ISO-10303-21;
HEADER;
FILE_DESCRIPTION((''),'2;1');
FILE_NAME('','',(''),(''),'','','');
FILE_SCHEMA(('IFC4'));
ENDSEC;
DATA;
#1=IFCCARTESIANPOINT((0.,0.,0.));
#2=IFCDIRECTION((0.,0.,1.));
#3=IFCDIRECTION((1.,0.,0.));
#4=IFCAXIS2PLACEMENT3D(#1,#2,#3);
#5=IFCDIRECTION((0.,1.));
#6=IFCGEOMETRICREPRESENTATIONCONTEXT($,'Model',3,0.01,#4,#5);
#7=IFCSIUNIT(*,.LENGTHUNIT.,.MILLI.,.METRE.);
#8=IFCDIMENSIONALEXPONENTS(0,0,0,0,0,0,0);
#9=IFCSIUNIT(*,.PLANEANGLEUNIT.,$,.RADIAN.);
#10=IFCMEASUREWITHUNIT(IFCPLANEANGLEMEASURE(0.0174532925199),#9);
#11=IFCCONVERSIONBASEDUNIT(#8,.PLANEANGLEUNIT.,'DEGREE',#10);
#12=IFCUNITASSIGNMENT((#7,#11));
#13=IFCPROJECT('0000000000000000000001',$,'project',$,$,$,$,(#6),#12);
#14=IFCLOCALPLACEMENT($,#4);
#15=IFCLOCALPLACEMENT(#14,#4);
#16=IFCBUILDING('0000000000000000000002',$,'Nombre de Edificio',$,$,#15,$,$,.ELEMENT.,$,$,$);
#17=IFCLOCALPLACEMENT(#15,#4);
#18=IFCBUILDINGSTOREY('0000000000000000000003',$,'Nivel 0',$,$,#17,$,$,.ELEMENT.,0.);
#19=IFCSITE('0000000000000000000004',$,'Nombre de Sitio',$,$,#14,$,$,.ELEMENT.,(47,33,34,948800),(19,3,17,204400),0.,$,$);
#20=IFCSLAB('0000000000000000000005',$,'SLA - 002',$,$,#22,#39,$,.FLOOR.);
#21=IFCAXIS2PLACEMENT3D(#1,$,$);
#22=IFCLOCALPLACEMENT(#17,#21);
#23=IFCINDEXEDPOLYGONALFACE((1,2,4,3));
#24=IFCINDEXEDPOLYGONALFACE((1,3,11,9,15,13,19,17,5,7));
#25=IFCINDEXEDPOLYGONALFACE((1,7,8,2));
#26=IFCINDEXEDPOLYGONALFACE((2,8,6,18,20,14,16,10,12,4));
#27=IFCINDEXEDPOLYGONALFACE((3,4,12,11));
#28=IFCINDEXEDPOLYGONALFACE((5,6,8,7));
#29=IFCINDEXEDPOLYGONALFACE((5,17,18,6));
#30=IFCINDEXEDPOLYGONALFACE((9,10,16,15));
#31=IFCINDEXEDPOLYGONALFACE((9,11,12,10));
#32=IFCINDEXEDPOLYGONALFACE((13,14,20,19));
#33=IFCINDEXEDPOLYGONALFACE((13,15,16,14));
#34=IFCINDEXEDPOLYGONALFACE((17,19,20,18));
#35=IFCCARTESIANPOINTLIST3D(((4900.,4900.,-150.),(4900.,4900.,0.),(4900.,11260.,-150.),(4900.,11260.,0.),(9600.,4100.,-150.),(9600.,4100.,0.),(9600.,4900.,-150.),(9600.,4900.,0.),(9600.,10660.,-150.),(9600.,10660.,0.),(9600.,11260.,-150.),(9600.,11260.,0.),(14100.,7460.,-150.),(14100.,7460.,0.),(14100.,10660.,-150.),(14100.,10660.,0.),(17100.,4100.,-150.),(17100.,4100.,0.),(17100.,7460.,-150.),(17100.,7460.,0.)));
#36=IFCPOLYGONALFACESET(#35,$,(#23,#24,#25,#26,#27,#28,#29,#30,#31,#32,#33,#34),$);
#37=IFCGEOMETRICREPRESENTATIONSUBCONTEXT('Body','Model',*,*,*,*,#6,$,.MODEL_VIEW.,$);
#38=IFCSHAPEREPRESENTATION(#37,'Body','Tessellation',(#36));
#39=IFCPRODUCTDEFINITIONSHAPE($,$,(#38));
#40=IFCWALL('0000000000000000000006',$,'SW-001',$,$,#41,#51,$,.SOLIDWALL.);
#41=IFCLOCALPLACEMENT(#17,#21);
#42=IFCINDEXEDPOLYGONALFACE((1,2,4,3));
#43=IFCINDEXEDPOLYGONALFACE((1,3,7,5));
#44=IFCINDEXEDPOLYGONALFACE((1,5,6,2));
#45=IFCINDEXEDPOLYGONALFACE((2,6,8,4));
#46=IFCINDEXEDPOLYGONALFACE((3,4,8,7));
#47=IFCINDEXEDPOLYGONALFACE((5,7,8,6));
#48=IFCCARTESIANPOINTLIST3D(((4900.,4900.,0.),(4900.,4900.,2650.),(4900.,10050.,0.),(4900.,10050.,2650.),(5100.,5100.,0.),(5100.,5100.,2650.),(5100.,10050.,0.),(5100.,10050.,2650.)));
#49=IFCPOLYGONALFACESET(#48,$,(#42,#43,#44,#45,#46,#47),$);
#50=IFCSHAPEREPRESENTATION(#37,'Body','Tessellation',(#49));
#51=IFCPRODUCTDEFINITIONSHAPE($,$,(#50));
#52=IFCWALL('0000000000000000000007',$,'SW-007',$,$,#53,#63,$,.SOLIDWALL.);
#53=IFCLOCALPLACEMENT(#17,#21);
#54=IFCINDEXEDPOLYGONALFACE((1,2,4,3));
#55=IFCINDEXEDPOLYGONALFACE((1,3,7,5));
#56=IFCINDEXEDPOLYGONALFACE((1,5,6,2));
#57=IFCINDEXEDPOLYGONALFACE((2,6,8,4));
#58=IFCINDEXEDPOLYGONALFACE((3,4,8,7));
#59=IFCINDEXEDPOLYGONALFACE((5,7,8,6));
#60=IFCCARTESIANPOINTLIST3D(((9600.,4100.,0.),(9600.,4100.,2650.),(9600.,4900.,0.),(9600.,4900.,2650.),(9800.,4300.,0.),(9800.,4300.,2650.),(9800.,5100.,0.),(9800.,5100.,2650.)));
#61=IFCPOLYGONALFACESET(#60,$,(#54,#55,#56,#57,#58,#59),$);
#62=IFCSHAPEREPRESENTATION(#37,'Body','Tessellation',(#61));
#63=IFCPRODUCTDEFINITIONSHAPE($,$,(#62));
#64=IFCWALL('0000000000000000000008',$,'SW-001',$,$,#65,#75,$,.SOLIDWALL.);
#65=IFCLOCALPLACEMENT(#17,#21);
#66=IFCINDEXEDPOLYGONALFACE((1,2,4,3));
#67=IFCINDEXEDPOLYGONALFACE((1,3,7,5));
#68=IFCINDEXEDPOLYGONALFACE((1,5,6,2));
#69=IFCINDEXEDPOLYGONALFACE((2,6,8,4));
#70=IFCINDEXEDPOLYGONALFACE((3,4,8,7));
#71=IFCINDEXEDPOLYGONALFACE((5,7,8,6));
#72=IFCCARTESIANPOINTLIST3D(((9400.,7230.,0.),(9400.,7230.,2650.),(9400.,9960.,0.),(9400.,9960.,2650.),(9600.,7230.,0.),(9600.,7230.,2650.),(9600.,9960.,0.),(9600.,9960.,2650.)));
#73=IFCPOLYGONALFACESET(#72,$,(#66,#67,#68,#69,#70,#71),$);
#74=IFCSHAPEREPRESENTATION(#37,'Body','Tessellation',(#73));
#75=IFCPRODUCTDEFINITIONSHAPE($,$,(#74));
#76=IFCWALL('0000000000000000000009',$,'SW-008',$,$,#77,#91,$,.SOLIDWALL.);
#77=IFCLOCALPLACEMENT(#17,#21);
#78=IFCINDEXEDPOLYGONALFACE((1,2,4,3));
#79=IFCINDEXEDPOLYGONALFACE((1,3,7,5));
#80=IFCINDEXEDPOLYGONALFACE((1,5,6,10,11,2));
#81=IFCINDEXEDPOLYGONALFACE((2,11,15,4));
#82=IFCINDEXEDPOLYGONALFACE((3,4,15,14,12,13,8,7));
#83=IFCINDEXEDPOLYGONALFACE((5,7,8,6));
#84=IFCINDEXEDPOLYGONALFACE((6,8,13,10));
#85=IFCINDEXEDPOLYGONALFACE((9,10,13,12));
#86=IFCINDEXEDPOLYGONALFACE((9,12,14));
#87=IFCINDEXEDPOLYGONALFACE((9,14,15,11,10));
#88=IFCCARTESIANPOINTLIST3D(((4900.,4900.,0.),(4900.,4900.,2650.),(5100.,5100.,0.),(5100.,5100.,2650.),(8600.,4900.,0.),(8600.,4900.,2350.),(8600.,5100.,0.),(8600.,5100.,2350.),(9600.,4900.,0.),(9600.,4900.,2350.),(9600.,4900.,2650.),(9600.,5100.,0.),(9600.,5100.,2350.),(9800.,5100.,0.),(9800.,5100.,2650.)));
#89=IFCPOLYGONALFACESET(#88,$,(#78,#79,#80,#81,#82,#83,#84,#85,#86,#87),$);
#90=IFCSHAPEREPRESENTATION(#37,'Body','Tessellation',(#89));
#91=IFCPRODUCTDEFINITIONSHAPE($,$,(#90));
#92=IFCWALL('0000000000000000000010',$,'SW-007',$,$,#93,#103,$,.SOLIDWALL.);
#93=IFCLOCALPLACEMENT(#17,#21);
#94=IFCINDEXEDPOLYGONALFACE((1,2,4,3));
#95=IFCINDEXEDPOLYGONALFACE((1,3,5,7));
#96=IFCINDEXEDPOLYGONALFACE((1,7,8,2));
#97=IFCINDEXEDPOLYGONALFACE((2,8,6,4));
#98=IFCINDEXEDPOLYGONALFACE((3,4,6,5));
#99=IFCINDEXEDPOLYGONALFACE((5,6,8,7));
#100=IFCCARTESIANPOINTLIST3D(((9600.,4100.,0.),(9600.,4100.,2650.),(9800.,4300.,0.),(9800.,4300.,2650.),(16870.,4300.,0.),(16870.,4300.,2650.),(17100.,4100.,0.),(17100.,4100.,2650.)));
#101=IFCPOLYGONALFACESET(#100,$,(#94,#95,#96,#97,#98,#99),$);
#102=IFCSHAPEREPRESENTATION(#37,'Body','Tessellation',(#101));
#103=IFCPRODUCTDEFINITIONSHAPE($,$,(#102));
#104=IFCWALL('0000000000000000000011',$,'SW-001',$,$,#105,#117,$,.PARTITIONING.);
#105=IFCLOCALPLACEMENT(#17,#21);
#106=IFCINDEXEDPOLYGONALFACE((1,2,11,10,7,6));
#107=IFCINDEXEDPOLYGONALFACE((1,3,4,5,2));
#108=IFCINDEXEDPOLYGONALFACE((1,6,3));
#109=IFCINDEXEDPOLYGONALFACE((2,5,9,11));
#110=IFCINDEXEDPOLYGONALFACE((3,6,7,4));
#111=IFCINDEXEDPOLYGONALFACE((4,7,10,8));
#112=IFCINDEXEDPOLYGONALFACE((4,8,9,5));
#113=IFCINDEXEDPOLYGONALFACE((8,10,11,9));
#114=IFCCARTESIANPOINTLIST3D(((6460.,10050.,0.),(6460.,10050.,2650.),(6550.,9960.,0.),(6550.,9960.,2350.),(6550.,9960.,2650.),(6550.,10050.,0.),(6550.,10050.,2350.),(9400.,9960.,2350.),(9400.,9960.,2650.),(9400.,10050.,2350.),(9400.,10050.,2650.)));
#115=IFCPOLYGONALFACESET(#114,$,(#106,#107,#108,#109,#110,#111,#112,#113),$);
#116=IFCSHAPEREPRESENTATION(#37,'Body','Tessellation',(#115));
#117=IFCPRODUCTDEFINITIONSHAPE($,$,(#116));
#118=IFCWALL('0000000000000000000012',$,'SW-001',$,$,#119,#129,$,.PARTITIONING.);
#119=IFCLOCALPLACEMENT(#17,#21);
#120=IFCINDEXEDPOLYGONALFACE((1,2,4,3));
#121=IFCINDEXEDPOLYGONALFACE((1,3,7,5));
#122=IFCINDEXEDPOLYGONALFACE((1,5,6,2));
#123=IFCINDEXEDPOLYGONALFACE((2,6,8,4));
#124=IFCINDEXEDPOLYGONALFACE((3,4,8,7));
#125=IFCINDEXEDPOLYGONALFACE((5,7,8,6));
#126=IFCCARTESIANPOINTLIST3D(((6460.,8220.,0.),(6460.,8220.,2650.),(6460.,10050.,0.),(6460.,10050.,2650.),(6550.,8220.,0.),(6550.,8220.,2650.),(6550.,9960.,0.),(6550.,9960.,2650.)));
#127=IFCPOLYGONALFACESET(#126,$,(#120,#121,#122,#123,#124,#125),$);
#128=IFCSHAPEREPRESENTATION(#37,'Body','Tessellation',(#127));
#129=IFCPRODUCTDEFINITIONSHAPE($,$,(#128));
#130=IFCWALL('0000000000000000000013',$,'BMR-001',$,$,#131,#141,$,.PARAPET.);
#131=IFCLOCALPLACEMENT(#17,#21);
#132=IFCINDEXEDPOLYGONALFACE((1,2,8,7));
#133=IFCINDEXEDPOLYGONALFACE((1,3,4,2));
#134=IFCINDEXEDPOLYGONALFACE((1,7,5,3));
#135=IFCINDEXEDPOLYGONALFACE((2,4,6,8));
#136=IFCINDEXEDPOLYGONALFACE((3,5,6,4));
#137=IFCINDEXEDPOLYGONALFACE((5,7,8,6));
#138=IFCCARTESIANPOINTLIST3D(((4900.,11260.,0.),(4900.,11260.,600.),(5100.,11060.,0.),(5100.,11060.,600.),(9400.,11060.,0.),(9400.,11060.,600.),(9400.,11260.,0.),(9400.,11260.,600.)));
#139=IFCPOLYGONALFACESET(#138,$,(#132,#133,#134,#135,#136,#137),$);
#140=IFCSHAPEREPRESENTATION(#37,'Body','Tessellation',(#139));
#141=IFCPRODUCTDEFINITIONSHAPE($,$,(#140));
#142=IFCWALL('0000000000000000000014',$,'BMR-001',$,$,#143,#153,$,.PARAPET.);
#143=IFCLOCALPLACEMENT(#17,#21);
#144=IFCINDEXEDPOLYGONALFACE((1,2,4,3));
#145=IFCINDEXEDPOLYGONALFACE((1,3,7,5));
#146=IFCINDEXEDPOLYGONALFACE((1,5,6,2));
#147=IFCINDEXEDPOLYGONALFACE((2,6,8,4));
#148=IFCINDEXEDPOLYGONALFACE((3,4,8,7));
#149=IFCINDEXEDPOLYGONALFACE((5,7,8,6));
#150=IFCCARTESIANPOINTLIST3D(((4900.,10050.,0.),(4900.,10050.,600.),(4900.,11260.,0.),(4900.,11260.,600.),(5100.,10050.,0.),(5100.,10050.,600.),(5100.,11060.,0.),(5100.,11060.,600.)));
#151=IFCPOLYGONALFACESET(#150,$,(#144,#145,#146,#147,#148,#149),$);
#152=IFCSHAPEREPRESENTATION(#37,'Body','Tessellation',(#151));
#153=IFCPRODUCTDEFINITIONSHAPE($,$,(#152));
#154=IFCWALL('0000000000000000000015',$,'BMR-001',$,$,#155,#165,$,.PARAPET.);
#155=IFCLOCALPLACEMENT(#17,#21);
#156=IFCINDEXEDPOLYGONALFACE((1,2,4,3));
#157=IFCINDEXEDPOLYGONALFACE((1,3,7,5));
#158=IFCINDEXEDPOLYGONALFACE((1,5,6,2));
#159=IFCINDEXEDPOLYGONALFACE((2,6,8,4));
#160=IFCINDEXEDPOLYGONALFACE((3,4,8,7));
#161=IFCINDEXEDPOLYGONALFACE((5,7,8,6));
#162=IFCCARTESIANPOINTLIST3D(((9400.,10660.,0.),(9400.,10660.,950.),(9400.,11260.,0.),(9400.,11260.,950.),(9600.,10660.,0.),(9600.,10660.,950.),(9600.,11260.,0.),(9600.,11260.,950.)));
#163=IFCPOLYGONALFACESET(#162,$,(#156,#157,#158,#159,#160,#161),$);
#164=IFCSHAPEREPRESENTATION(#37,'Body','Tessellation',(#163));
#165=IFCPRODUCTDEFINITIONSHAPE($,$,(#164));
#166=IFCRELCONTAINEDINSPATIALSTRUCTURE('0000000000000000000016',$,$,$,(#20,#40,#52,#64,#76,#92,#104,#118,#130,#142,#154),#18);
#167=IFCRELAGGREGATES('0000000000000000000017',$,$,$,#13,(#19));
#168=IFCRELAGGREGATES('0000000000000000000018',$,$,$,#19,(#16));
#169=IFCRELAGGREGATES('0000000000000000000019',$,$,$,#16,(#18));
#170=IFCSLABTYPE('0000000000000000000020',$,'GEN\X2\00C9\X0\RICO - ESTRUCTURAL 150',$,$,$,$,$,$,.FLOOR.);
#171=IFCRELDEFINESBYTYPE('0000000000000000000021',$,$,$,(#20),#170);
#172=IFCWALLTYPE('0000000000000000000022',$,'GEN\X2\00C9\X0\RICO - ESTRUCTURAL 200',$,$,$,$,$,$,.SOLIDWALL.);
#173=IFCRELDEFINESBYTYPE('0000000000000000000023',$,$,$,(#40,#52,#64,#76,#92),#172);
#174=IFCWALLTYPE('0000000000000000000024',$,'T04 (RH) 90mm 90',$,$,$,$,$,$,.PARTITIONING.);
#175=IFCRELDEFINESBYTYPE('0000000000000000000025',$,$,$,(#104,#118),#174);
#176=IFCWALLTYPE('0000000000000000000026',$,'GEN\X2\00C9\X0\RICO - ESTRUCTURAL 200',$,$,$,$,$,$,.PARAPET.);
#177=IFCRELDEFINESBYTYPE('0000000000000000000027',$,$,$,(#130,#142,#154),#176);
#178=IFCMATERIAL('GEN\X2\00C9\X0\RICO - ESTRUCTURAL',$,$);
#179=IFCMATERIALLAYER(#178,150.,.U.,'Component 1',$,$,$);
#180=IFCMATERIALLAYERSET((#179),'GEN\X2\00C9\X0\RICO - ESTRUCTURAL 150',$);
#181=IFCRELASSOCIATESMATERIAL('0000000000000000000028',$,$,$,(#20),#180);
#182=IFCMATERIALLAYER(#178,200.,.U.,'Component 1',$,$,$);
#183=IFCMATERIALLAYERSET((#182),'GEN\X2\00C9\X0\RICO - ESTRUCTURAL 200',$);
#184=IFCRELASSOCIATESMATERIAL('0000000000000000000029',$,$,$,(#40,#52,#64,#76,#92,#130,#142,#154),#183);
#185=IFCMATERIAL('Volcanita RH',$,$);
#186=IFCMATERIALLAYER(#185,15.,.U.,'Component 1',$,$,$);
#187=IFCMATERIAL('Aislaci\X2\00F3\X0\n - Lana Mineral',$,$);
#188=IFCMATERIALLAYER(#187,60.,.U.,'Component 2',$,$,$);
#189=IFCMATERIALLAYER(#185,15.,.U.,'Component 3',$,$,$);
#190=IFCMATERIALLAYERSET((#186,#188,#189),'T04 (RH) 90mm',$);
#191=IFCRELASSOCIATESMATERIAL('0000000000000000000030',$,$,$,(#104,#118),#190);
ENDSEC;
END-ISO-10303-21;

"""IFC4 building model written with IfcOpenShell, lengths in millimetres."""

from ifc_helpers import new_model, entity, si_unit, converted_unit, direction, frame, origin_with_axes, origin_2d_with_axis, place, context, subcontext, project, spatial, line, indexed_curve, rectangle, outline, extrude, material, layer, layer_set, layer_usage, type_object, element, save


model = new_model("IFC4")

# Units and contexts
model_context = context("Model", 3, precision=0.01, world=origin_with_axes(), true_north=direction((0.0, 1.0)))
body_context = subcontext(model_context, "Body", "Model", "MODEL_VIEW")
ifc_project = project(units=[si_unit("LENGTHUNIT", "METRE", prefix="MILLI"), converted_unit("PLANEANGLEUNIT", "DEGREE", entity("IfcPlaneAngleMeasure", 0.0174532925199), si_unit("PLANEANGLEUNIT", "RADIAN"), dimensions=[0, 0, 0, 0, 0, 0, 0])], contexts=[model_context])

# Site, building, storey
site_placement = place(None, origin_with_axes())
site = spatial("IfcSite", under=ifc_project, at=site_placement, Name="Nombre de Sitio", CompositionType="ELEMENT", RefLatitude=(47, 33, 34, 948800), RefLongitude=(19, 3, 17, 204400), RefElevation=0.0)
building_placement = place(site_placement, origin_with_axes())
building = spatial("IfcBuilding", under=site, at=building_placement, Name="Nombre de Edificio", CompositionType="ELEMENT")
storey_placement = place(building_placement, origin_with_axes())
storey = spatial("IfcBuildingStorey", under=building, at=storey_placement, Name="Nivel 0", CompositionType="ELEMENT", Elevation=0.0)

# Slab
ifc_material_1 = material(Name="GENÉRICO - ESTRUCTURAL")
ifc_layer_1 = layer(ifc_material_1, 150.0, ventilated="UNKNOWN", Name="Component 1")
ifc_layer_set_1 = layer_set([ifc_layer_1], Name="GENÉRICO - ESTRUCTURAL 150")
ifc_layer_usage_1 = layer_usage(ifc_layer_set_1, "AXIS3", "NEGATIVE", 150.0)
slab_type = type_object("IfcSlabType", Name="GENÉRICO - ESTRUCTURAL 150", PredefinedType="FLOOR")
slab_placement = place(storey_placement, frame((4900.0, 4900.0, 0.0), z_axis=(0.0, 0.0, 1.0), x_axis=(1.0, 0.0, 0.0)))
element("IfcSlab", 1, at=slab_placement, inside=storey, type_object=slab_type, material=ifc_layer_usage_1, Name="SLA - 002", PredefinedType="FLOOR", context=body_context, shape_type="SweptSolid", body=[
    extrude(outline(indexed_curve([(0.0, 0.0), (4700.0, 0.0), (4700.0, -800.0), (12200.0, -800.0), (12200.0, 2560.0), (9200.0, 2560.0), (9200.0, 5760.0), (4700.0, 5760.0), (4700.0, 6360.0), (0.0, 6360.0)], segments=[line(1, 2, 3, 4, 5, 6, 7, 8, 9, 10, 1)])), frame((0.0, 0.0, -150.0), z_axis=(0.0, 0.0, 1.0), x_axis=(1.0, 0.0, 0.0)), (0.0, 0.0, 1.0), 150.0),
])

# Walls
ifc_layer_2 = layer(ifc_material_1, 200.0, ventilated="UNKNOWN", Name="Component 1")
ifc_layer_set_2 = layer_set([ifc_layer_2], Name="GENÉRICO - ESTRUCTURAL 200")
ifc_layer_usage_2 = layer_usage(ifc_layer_set_2, "AXIS2", "POSITIVE", -100.0)
wall_type_1 = type_object("IfcWallType", Name="GENÉRICO - ESTRUCTURAL 200", PredefinedType="SOLIDWALL")
wall_1_placement = place(storey_placement, frame((5000.0, 5000.0, 0.0), z_axis=(0.0, 0.0, 1.0), x_axis=(0.0, 1.0, 0.0)))
element("IfcWall", 2, at=wall_1_placement, inside=storey, type_object=wall_type_1, material=ifc_layer_usage_2, Name="SW-001", PredefinedType="SOLIDWALL", context=body_context, shape_type="SweptSolid", body=[
    extrude(outline(indexed_curve([(100.0, -100.0), (5050.0, -100.0), (5050.0, 100.0), (-100.0, 100.0)], segments=[line(1, 2, 3, 4, 1)])), origin_with_axes(), (0.0, 0.0, 1.0), 2650.0),
])
ifc_layer_usage_3 = layer_usage(ifc_layer_set_2, "AXIS2", "POSITIVE", -100.0)
wall_2_placement = place(storey_placement, frame((9700.0, 4200.0, 0.0), z_axis=(0.0, 0.0, 1.0), x_axis=(0.0, 1.0, 0.0)))
element("IfcWall", 3, at=wall_2_placement, inside=storey, type_object=wall_type_1, material=ifc_layer_usage_3, Name="SW-007", PredefinedType="SOLIDWALL", context=body_context, shape_type="SweptSolid", body=[
    extrude(outline(indexed_curve([(100.0, -100.0), (900.0, -100.0), (700.0, 100.0), (-100.0, 100.0)], segments=[line(1, 2, 3, 4, 1)])), origin_with_axes(), (0.0, 0.0, 1.0), 2650.0),
])
ifc_layer_usage_4 = layer_usage(ifc_layer_set_2, "AXIS2", "POSITIVE", -100.0)
wall_3_placement = place(storey_placement, frame((9500.0, 7230.0, 0.0), z_axis=(0.0, 0.0, 1.0), x_axis=(0.0, 1.0, 0.0)))
element("IfcWall", 4, at=wall_3_placement, inside=storey, type_object=wall_type_1, material=ifc_layer_usage_4, Name="SW-001", PredefinedType="SOLIDWALL", context=body_context, shape_type="SweptSolid", body=[
    extrude(outline(indexed_curve([(0.0, -100.0), (2730.0, -100.0), (2730.0, 100.0), (0.0, 100.0)], segments=[line(1, 2, 3, 4, 1)])), origin_with_axes(), (0.0, 0.0, 1.0), 2650.0),
])

# Wall, opening
ifc_layer_usage_5 = layer_usage(ifc_layer_set_2, "AXIS2", "POSITIVE", -100.0)
wall_4_placement = place(storey_placement, frame((9700.0, 5000.0, 0.0), z_axis=(0.0, 0.0, 1.0), x_axis=(-1.0, 0.0, 0.0)))
wall_4 = element("IfcWall", 5, at=wall_4_placement, inside=storey, type_object=wall_type_1, material=ifc_layer_usage_5, Name="SW-008", PredefinedType="SOLIDWALL", context=body_context, shape_type="SweptSolid", body=[
    extrude(outline(indexed_curve([(-100.0, -100.0), (4600.0, -100.0), (4800.0, 100.0), (100.0, 100.0)], segments=[line(1, 2, 3, 4, 1)])), origin_with_axes(), (0.0, 0.0, 1.0), 2650.0),
])
opening_1_placement = place(wall_4_placement, frame((600.0, 0.0, 0.0), z_axis=(0.0, 0.0, 1.0), x_axis=(1.0, 0.0, 0.0)))
element("IfcOpeningElement", 6, at=opening_1_placement, cuts=wall_4, context=body_context, shape_type="SweptSolid", body=[
    extrude(rectangle(XDim=1000.0, YDim=2350.0, at=origin_2d_with_axis()), frame((0.0, 200.0, 1175.0), z_axis=(0.0, -1.0, 0.0), x_axis=(-1.0, 0.0, 0.0)), (0.0, 0.0, 1.0), 600.0),
])

# Wall
ifc_layer_usage_6 = layer_usage(ifc_layer_set_2, "AXIS2", "POSITIVE", -100.0)
wall_5_placement = place(storey_placement, frame((9700.0, 4200.0, 0.0), z_axis=(0.0, 0.0, 1.0), x_axis=(1.0, 0.0, 0.0)))
element("IfcWall", 7, at=wall_5_placement, inside=storey, type_object=wall_type_1, material=ifc_layer_usage_6, Name="SW-007", PredefinedType="SOLIDWALL", context=body_context, shape_type="SweptSolid", body=[
    extrude(outline(indexed_curve([(-100.0, -100.0), (7400.0, -100.0), (7170.0, 100.0), (100.0, 100.0)], segments=[line(1, 2, 3, 4, 1)])), origin_with_axes(), (0.0, 0.0, 1.0), 2650.0),
])

# Wall, opening
ifc_material_2 = material(Name="Volcanita RH")
ifc_layer_3 = layer(ifc_material_2, 15.0, ventilated="UNKNOWN", Name="Component 1")
ifc_material_3 = material(Name="Aislación - Lana Mineral")
ifc_layer_4 = layer(ifc_material_3, 60.0, ventilated="UNKNOWN", Name="Component 2")
ifc_layer_5 = layer(ifc_material_2, 15.0, ventilated="UNKNOWN", Name="Component 3")
ifc_layer_set_3 = layer_set([ifc_layer_3, ifc_layer_4, ifc_layer_5], Name="T04 (RH) 90mm")
wall_type_2 = type_object("IfcWallType", Name="T04 (RH) 90mm 90", PredefinedType="PARTITIONING")
ifc_layer_usage_7 = layer_usage(ifc_layer_set_3, "AXIS2", "POSITIVE", -45.0)
wall_6_placement = place(storey_placement, frame((6505.0, 10005.0, 0.0), z_axis=(0.0, 0.0, 1.0), x_axis=(1.0, 0.0, 0.0)))
wall_6 = element("IfcWall", 8, at=wall_6_placement, inside=storey, type_object=wall_type_2, material=ifc_layer_usage_7, Name="SW-001", PredefinedType="PARTITIONING", context=body_context, shape_type="SweptSolid", body=[
    extrude(outline(indexed_curve([(45.0, -45.0), (2895.0, -45.0), (2895.0, 45.0), (-45.0, 45.0)], segments=[line(1, 2, 3, 4, 1)])), origin_with_axes(), (0.0, 0.0, 1.0), 2650.0),
])
opening_2_placement = place(wall_6_placement, frame((1470.0, 0.0, 0.0), z_axis=(0.0, 0.0, 1.0), x_axis=(1.0, 0.0, 0.0)))
element("IfcOpeningElement", 9, at=opening_2_placement, cuts=wall_6, context=body_context, shape_type="SweptSolid", body=[
    extrude(rectangle(XDim=2850.0, YDim=2350.0, at=origin_2d_with_axis()), frame((0.0, 90.0, 1175.0), z_axis=(0.0, -1.0, 0.0), x_axis=(1.0, 0.0, 0.0)), (0.0, 0.0, 1.0), 270.0),
])

# Walls
ifc_layer_usage_8 = layer_usage(ifc_layer_set_3, "AXIS2", "POSITIVE", -45.0)
wall_7_placement = place(storey_placement, frame((6505.0, 10005.0, 0.0), z_axis=(0.0, 0.0, 1.0), x_axis=(0.0, -1.0, 0.0)))
element("IfcWall", 10, at=wall_7_placement, inside=storey, type_object=wall_type_2, material=ifc_layer_usage_8, Name="SW-001", PredefinedType="PARTITIONING", context=body_context, shape_type="SweptSolid", body=[
    extrude(outline(indexed_curve([(-45.0, -45.0), (1785.0, -45.0), (1785.0, 45.0), (45.0, 45.0)], segments=[line(1, 2, 3, 4, 1)])), origin_with_axes(), (0.0, 0.0, 1.0), 2650.0),
])
ifc_layer_usage_9 = layer_usage(ifc_layer_set_2, "AXIS2", "POSITIVE", -100.0)
wall_type_3 = type_object("IfcWallType", Name="GENÉRICO - ESTRUCTURAL 200", PredefinedType="PARAPET")
wall_8_placement = place(storey_placement, frame((5000.0, 11160.0, 0.0), z_axis=(0.0, 0.0, 1.0), x_axis=(1.0, 0.0, 0.0)))
element("IfcWall", 11, at=wall_8_placement, inside=storey, type_object=wall_type_3, material=ifc_layer_usage_9, Name="BMR-001", PredefinedType="PARAPET", context=body_context, shape_type="SweptSolid", body=[
    extrude(outline(indexed_curve([(100.0, -100.0), (4400.0, -100.0), (4400.0, 100.0), (-100.0, 100.0)], segments=[line(1, 2, 3, 4, 1)])), origin_with_axes(), (0.0, 0.0, 1.0), 600.0),
])
ifc_layer_usage_10 = layer_usage(ifc_layer_set_2, "AXIS2", "POSITIVE", -100.0)
wall_9_placement = place(storey_placement, frame((5000.0, 10050.0, 0.0), z_axis=(0.0, 0.0, 1.0), x_axis=(0.0, 1.0, 0.0)))
element("IfcWall", 12, at=wall_9_placement, inside=storey, type_object=wall_type_3, material=ifc_layer_usage_10, Name="BMR-001", PredefinedType="PARAPET", context=body_context, shape_type="SweptSolid", body=[
    extrude(outline(indexed_curve([(0.0, -100.0), (1010.0, -100.0), (1210.0, 100.0), (0.0, 100.0)], segments=[line(1, 2, 3, 4, 1)])), origin_with_axes(), (0.0, 0.0, 1.0), 600.0),
])
ifc_layer_usage_11 = layer_usage(ifc_layer_set_2, "AXIS2", "POSITIVE", -100.0)
wall_10_placement = place(storey_placement, frame((9500.0, 10660.0, 0.0), z_axis=(0.0, 0.0, 1.0), x_axis=(0.0, 1.0, 0.0)))
element("IfcWall", 13, at=wall_10_placement, inside=storey, type_object=wall_type_3, material=ifc_layer_usage_11, Name="BMR-001", PredefinedType="PARAPET", context=body_context, shape_type="SweptSolid", body=[
    extrude(outline(indexed_curve([(0.0, -100.0), (600.0, -100.0), (600.0, 100.0), (0.0, 100.0)], segments=[line(1, 2, 3, 4, 1)])), origin_with_axes(), (0.0, 0.0, 1.0), 950.0),
])

save(model, "model.ifc")
